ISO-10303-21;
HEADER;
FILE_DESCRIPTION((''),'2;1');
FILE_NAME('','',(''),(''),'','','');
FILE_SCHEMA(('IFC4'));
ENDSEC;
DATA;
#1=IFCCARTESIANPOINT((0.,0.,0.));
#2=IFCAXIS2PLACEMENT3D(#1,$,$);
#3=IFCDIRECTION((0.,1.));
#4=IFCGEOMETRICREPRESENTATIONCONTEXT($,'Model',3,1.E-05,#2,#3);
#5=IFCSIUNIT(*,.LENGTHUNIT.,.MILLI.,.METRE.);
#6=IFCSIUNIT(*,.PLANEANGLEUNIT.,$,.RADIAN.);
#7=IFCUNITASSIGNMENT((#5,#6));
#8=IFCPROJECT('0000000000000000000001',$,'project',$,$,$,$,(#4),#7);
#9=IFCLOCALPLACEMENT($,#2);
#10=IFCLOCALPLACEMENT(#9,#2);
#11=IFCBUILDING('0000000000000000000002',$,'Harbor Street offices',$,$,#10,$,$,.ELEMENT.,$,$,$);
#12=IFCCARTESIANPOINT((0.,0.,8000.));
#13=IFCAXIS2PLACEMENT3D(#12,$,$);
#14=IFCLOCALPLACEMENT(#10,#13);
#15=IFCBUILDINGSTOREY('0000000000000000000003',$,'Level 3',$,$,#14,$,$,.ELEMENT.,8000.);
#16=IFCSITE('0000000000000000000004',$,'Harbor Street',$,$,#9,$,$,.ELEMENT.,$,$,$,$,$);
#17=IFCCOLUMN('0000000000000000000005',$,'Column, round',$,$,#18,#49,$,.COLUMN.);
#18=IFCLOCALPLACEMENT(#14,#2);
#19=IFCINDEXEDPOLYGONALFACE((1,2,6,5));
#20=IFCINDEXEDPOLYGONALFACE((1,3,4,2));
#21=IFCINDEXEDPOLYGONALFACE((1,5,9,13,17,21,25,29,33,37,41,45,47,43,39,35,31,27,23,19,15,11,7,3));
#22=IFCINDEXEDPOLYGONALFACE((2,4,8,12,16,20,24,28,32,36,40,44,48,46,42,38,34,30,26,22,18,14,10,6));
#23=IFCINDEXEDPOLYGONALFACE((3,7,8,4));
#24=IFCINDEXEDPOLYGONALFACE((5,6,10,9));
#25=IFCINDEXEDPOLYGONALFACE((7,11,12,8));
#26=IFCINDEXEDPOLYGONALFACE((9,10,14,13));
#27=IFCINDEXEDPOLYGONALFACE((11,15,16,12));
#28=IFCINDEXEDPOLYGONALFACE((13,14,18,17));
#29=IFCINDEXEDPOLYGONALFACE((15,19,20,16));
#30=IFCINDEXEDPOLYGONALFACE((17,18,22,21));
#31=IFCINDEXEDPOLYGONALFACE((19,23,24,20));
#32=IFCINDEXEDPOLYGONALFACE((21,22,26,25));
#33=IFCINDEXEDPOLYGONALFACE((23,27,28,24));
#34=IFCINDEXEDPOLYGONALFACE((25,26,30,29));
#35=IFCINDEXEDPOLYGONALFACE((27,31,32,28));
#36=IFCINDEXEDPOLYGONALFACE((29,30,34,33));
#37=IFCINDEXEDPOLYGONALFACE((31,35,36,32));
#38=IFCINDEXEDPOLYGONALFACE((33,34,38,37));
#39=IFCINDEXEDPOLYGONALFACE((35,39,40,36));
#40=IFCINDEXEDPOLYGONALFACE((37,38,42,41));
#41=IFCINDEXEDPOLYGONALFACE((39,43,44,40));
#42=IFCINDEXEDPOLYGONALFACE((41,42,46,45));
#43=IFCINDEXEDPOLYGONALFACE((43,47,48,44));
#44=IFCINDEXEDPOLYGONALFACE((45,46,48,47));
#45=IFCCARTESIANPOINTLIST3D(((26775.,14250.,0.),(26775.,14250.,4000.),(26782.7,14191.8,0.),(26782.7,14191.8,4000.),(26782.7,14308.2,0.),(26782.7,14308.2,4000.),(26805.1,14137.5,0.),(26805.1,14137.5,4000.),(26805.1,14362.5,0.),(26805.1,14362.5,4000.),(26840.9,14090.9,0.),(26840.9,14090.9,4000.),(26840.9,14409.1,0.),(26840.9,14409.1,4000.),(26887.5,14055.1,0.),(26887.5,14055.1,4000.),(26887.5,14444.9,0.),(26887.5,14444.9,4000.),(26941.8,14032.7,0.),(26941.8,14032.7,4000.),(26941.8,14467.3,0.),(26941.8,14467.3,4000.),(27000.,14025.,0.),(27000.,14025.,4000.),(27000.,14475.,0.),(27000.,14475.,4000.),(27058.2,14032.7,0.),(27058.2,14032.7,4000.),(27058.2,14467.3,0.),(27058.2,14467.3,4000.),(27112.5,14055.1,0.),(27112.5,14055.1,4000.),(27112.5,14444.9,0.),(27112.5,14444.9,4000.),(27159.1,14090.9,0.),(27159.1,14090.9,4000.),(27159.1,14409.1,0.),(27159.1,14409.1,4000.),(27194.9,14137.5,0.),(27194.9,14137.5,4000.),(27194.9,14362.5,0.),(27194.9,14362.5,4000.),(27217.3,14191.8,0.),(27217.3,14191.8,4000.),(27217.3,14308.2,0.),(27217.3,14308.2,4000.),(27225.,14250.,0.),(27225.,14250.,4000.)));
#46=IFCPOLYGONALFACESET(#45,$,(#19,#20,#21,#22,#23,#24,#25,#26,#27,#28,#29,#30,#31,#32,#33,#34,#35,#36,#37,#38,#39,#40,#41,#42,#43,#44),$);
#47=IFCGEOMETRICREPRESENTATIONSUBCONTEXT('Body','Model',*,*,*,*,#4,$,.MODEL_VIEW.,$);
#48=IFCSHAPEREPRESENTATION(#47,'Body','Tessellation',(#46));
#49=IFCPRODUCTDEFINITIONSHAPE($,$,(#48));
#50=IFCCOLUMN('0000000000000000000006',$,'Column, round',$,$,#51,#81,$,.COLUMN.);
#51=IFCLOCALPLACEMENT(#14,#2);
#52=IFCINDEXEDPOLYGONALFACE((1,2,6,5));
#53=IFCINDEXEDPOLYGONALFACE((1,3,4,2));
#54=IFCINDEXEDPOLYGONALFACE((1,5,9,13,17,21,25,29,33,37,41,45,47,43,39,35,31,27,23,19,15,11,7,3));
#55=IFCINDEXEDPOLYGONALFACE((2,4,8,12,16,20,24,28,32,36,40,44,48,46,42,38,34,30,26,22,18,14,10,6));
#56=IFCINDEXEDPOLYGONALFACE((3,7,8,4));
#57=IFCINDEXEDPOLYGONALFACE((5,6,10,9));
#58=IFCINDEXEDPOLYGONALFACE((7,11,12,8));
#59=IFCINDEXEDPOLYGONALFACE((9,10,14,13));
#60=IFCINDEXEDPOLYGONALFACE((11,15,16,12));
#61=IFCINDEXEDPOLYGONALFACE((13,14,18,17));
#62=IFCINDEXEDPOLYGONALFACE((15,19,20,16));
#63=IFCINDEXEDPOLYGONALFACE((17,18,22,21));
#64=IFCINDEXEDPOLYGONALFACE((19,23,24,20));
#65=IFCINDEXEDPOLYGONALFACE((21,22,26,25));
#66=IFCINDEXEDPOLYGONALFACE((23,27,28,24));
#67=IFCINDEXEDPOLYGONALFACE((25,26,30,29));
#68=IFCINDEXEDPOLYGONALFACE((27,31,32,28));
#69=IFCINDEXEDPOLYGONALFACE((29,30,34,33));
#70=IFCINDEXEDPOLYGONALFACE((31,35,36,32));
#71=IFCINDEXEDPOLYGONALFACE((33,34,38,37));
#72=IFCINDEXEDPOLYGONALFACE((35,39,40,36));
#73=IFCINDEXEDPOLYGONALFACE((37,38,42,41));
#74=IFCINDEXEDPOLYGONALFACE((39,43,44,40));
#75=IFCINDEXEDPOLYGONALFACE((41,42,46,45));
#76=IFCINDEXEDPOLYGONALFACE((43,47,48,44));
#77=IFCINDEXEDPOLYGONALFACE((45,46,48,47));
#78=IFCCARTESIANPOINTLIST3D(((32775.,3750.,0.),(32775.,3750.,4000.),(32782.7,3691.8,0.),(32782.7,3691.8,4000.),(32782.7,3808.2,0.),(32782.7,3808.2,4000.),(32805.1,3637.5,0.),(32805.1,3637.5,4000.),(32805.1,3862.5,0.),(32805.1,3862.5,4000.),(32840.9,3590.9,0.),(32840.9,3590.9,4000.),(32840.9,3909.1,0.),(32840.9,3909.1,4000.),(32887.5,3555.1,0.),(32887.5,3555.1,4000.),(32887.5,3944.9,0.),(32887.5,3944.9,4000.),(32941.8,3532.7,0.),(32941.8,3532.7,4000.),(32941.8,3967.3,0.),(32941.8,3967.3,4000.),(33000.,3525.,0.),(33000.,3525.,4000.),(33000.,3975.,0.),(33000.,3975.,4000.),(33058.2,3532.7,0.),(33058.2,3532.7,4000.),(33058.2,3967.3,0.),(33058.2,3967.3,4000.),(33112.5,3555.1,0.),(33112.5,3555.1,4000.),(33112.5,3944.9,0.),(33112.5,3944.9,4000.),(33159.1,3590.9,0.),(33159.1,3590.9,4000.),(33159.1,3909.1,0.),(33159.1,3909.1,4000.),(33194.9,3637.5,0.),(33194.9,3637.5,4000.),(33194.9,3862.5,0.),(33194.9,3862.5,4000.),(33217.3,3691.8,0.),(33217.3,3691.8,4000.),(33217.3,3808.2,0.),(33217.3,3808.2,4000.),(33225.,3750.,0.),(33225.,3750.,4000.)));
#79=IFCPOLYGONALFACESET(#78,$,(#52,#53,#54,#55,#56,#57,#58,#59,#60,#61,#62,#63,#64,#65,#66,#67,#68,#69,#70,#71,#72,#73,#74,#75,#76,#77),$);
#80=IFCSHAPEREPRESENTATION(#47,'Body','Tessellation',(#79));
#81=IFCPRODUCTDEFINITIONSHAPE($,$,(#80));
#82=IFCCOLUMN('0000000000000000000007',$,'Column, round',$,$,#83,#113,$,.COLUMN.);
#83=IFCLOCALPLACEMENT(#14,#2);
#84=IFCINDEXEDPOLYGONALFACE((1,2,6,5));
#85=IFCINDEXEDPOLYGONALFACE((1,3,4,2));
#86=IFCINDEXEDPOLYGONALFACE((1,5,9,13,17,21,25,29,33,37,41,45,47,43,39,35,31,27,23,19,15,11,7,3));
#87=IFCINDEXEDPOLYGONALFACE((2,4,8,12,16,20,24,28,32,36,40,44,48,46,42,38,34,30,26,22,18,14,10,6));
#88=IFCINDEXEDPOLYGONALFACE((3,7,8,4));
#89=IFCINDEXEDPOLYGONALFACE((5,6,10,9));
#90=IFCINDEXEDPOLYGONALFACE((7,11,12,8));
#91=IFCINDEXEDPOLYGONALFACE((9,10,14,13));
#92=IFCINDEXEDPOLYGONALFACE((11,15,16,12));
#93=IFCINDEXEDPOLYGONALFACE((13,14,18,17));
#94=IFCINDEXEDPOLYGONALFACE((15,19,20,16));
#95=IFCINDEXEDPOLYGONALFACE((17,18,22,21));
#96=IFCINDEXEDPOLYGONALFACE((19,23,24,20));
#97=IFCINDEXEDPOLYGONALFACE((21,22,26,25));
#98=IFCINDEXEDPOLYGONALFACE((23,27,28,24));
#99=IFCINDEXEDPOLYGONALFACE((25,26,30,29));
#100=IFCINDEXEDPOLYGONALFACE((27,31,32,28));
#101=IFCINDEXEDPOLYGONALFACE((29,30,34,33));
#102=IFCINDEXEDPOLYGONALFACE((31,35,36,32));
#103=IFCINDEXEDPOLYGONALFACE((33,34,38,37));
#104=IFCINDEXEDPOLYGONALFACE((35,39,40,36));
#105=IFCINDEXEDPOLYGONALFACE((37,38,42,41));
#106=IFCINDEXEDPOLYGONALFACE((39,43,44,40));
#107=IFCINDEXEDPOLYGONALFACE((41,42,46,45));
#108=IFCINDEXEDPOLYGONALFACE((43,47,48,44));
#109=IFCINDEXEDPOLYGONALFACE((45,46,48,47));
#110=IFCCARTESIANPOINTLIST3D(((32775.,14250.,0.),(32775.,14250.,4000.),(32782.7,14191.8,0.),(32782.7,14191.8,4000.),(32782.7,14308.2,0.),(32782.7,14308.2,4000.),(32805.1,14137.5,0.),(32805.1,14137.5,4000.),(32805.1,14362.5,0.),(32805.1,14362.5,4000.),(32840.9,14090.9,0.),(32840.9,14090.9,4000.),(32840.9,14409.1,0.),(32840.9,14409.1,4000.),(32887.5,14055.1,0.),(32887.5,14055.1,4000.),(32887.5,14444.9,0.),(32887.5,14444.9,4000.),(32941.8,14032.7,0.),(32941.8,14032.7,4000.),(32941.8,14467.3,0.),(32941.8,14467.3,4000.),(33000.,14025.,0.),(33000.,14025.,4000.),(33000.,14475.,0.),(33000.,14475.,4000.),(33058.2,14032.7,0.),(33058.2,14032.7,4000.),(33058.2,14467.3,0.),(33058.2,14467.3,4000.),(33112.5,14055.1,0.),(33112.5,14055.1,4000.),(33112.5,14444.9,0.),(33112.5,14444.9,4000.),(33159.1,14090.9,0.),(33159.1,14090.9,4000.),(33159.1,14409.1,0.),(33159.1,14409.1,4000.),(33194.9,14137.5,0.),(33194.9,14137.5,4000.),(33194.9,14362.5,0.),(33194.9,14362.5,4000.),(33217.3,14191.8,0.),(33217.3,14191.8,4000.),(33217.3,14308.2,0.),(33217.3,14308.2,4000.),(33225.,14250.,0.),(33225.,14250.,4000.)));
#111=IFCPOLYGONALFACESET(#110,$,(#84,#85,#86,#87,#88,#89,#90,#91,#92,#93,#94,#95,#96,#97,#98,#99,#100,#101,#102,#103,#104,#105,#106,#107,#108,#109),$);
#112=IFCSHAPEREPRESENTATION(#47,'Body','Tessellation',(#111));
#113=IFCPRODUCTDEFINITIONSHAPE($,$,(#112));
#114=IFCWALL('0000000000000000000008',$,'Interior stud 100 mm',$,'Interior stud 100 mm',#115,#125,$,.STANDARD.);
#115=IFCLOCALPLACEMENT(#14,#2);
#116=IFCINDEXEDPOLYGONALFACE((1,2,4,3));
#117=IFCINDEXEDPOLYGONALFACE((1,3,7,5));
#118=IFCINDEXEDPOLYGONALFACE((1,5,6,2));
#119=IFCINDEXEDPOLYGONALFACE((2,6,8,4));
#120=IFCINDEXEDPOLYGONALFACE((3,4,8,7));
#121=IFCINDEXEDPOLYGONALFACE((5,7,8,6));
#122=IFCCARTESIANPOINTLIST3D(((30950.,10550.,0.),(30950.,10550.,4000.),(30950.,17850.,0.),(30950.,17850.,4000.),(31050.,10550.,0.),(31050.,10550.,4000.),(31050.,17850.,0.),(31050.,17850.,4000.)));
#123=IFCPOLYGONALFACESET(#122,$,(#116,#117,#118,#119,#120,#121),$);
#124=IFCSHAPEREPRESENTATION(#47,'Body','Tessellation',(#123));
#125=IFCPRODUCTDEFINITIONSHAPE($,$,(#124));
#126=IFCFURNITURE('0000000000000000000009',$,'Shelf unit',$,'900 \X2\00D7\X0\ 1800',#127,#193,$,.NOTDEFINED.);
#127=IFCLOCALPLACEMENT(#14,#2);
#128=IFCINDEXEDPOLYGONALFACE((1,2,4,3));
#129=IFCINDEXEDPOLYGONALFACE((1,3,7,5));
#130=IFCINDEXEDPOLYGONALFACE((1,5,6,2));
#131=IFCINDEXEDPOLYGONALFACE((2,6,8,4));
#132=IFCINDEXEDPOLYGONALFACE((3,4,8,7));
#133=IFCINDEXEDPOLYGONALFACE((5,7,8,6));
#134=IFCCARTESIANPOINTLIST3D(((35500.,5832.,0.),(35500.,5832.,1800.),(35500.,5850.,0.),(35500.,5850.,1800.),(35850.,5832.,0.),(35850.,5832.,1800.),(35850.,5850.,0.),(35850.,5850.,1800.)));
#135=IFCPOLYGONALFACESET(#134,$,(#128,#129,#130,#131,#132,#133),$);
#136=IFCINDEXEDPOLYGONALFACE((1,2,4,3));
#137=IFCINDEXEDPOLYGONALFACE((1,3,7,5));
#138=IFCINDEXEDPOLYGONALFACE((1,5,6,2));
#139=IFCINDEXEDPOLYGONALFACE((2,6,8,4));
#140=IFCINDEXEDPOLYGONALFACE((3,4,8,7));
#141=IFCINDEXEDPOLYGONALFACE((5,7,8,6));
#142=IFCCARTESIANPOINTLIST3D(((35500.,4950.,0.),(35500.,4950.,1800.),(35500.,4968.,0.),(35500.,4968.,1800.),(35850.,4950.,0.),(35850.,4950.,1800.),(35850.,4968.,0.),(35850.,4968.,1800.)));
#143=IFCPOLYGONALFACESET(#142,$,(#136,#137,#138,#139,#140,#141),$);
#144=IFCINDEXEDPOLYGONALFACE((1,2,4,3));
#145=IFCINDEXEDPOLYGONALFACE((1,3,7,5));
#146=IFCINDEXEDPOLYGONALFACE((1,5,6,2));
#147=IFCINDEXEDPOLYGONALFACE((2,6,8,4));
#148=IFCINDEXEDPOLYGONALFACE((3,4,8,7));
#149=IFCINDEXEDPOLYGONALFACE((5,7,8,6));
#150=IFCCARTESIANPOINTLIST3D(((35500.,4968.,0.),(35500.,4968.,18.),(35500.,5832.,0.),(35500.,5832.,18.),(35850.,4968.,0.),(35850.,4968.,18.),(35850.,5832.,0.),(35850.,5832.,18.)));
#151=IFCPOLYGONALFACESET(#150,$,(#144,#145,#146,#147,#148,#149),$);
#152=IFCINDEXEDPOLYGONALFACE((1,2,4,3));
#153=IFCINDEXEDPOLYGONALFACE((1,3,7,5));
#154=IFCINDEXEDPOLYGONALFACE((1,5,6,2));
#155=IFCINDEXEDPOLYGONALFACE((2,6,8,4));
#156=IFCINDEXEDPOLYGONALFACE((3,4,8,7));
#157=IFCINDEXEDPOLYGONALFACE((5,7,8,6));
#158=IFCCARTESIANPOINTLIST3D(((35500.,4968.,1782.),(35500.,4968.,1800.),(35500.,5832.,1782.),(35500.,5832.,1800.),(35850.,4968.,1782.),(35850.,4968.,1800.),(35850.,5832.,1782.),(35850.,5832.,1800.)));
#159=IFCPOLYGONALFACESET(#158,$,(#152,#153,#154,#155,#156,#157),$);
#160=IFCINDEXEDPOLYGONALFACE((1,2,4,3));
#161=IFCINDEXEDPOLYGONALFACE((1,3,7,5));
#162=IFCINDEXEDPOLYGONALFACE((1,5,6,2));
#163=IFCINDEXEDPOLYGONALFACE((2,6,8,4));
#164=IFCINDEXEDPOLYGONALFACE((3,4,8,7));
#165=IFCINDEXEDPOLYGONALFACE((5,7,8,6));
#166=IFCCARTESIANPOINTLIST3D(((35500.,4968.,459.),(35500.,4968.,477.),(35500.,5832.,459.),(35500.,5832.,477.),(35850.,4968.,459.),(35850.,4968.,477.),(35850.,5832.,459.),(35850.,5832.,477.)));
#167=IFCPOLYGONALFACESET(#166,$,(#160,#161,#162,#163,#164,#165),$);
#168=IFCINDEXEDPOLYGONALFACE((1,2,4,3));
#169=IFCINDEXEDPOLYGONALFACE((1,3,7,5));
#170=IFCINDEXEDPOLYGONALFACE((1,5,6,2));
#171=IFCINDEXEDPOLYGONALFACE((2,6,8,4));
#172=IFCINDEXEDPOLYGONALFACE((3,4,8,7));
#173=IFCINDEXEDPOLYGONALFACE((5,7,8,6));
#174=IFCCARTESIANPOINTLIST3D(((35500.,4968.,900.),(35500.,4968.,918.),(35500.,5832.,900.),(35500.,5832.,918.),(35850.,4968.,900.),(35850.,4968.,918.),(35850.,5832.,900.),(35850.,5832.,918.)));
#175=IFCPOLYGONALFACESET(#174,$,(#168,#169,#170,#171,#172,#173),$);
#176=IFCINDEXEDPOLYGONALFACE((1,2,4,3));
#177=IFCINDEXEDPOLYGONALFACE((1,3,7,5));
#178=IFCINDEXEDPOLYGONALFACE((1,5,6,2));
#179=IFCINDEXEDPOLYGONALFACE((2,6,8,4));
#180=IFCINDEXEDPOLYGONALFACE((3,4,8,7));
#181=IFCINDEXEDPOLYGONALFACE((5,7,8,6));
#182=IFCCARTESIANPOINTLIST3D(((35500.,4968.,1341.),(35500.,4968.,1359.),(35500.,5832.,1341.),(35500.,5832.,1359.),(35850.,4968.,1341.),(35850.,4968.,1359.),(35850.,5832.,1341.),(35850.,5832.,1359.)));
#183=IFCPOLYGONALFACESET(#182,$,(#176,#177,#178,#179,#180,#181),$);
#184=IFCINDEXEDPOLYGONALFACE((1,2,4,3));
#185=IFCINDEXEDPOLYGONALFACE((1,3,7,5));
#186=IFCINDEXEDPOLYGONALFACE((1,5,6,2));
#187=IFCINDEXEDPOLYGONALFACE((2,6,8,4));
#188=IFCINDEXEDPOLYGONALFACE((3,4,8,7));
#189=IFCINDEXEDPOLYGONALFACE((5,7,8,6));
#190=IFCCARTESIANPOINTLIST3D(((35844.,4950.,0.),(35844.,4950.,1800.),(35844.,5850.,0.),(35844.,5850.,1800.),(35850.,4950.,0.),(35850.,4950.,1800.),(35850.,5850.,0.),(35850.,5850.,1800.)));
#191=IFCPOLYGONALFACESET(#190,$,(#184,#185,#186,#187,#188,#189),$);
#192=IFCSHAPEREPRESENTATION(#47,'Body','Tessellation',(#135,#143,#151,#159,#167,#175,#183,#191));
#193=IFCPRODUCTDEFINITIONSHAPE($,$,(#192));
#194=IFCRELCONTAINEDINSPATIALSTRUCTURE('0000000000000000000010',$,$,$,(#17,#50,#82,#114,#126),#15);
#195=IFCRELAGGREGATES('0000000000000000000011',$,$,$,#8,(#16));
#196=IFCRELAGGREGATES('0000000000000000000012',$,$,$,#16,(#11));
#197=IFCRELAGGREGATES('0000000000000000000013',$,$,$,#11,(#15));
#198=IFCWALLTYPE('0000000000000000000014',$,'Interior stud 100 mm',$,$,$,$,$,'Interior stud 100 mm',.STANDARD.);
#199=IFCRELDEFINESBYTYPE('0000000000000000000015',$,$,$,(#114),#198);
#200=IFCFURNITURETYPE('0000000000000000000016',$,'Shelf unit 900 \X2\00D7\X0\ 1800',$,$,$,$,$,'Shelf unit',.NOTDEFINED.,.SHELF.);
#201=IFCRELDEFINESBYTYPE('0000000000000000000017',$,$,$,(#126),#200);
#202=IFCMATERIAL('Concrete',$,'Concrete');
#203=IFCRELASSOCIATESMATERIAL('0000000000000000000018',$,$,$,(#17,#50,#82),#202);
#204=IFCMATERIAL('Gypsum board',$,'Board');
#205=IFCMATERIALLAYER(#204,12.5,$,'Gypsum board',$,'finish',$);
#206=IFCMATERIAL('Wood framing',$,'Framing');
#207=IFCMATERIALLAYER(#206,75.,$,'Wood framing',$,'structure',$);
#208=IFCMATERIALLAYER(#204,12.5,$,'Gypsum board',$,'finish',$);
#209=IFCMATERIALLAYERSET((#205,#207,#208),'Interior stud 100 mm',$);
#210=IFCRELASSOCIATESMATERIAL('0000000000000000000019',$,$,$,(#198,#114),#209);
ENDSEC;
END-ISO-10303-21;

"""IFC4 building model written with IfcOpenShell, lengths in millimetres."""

from ifc_helpers import new_model, si_unit, direction, frame, origin, origin_2d, place, context, subcontext, project, spatial, polyline, circle, outline, extrude, source, transform, mapped, material, layer, layer_set, layer_usage, type_object, type_shapes, element, save


model = new_model("IFC4")

# Units and contexts
model_context = context("Model", 3, precision=1e-05, world=origin(), true_north=direction((0.0, 1.0)))
body_context = subcontext(model_context, "Body", "Model", "MODEL_VIEW")
ifc_project = project(units=[si_unit("LENGTHUNIT", "METRE", prefix="MILLI"), si_unit("PLANEANGLEUNIT", "RADIAN")], contexts=[model_context])

# Site, building, storey
site_placement = place(None, origin())
site = spatial("IfcSite", under=ifc_project, at=site_placement, Name="Harbor Street", CompositionType="ELEMENT")
building_placement = place(site_placement, origin())
building = spatial("IfcBuilding", under=site, at=building_placement, Name="Harbor Street offices", CompositionType="ELEMENT")
storey_placement = place(building_placement, frame((0.0, 0.0, 8000.0)))
storey = spatial("IfcBuildingStorey", under=building, at=storey_placement, Name="Level 3", CompositionType="ELEMENT", Elevation=8000.0)

# Columns
ifc_material_1 = material(Name="Concrete", Category="Concrete")
for number, where, z_axis, x_axis, name in (
    (1, (27000.0, 14250.0, 0.0), (0.0, 0.0, 1.0), (1.0, 0.0, 0.0), "Column, round"),
    (2, (33000.0, 3750.0, 0.0), (0.0, 0.0, 1.0), (1.0, 0.0, 0.0), "Column, round"),
    (3, (33000.0, 14250.0, 0.0), (0.0, 0.0, 1.0), (1.0, 0.0, 0.0), "Column, round"),
):
    element("IfcColumn", number, at=place(storey_placement, frame(where, z_axis=z_axis, x_axis=x_axis)), inside=storey, material=ifc_material_1, Name=name, PredefinedType="COLUMN", context=body_context, shape_type="SweptSolid", body=[
        extrude(circle(Radius=225.0, at=origin_2d()), origin(), (0.0, 0.0, 1.0), 4000.0),
    ])

# Wall
ifc_material_2 = material(Name="Gypsum board", Category="Board")
ifc_layer_1 = layer(ifc_material_2, 12.5, Name="Gypsum board", Category="finish")
ifc_material_3 = material(Name="Wood framing", Category="Framing")
ifc_layer_2 = layer(ifc_material_3, 75.0, Name="Wood framing", Category="structure")
ifc_layer_3 = layer(ifc_material_2, 12.5, Name="Gypsum board", Category="finish")
ifc_layer_set_1 = layer_set([ifc_layer_1, ifc_layer_2, ifc_layer_3], Name="Interior stud 100 mm")
ifc_layer_usage_1 = layer_usage(ifc_layer_set_1, "AXIS2", "NEGATIVE", 50.0)
wall_type_1 = type_object("IfcWallType", Name="Interior stud 100 mm", ElementType="Interior stud 100 mm", PredefinedType="STANDARD", material=ifc_layer_set_1)
wall_1_placement = place(storey_placement, frame((31000.0, 10500.0, 0.0), z_axis=(0.0, 0.0, 1.0), x_axis=(0.0, 1.0, 0.0)))
element("IfcWall", 4, at=wall_1_placement, inside=storey, type_object=wall_type_1, material=ifc_layer_usage_1, Name="Interior stud 100 mm", ObjectType="Interior stud 100 mm", PredefinedType="STANDARD", context=body_context, shape_type="SweptSolid", body=[
    extrude(outline(polyline([(50.0, -50.0), (7350.0, -50.0), (7350.0, 50.0), (50.0, 50.0), (50.0, -50.0)])), origin(), (0.0, 0.0, 1.0), 4000.0),
])

# Furniture
furniture_type_1 = type_object("IfcFurnitureType", Name="Shelf unit 900 × 1800", ElementType="Shelf unit", AssemblyPlace="NOTDEFINED", PredefinedType="SHELF")
shared_shape_1 = source(origin(), body_context, "Body", "SweptSolid", [
    extrude(outline(polyline([(-450.0, 0.0), (-432.0, 0.0), (-432.0, 350.0), (-450.0, 350.0), (-450.0, 0.0)])), origin(), (0.0, 0.0, 1.0), 1800.0),
    extrude(outline(polyline([(432.0, 0.0), (450.0, 0.0), (450.0, 350.0), (432.0, 350.0), (432.0, 0.0)])), origin(), (0.0, 0.0, 1.0), 1800.0),
    extrude(outline(polyline([(-432.0, 0.0), (432.0, 0.0), (432.0, 350.0), (-432.0, 350.0), (-432.0, 0.0)])), origin(), (0.0, 0.0, 1.0), 18.0),
    extrude(outline(polyline([(-432.0, 0.0), (432.0, 0.0), (432.0, 350.0), (-432.0, 350.0), (-432.0, 0.0)])), frame((0.0, 0.0, 1782.0)), (0.0, 0.0, 1.0), 18.0),
    extrude(outline(polyline([(-432.0, 0.0), (432.0, 0.0), (432.0, 350.0), (-432.0, 350.0), (-432.0, 0.0)])), frame((0.0, 0.0, 459.0)), (0.0, 0.0, 1.0), 18.0),
    extrude(outline(polyline([(-432.0, 0.0), (432.0, 0.0), (432.0, 350.0), (-432.0, 350.0), (-432.0, 0.0)])), frame((0.0, 0.0, 900.0)), (0.0, 0.0, 1.0), 18.0),
    extrude(outline(polyline([(-432.0, 0.0), (432.0, 0.0), (432.0, 350.0), (-432.0, 350.0), (-432.0, 0.0)])), frame((0.0, 0.0, 1341.0)), (0.0, 0.0, 1.0), 18.0),
    extrude(outline(polyline([(-450.0, 344.0), (450.0, 344.0), (450.0, 350.0), (-450.0, 350.0), (-450.0, 344.0)])), origin(), (0.0, 0.0, 1.0), 1800.0),
])
type_shapes(furniture_type_1, [shared_shape_1])
furniture_placement = place(storey_placement, frame((35500.0, 5400.0, 0.0), z_axis=(0.0, 0.0, 1.0), x_axis=(0.0, -1.0, 0.0)))
element("IfcFurniture", 5, at=furniture_placement, inside=storey, type_object=furniture_type_1, Name="Shelf unit", ObjectType="900 × 1800", PredefinedType="NOTDEFINED", context=body_context, shape_type="MappedRepresentation", body=[
    mapped(shared_shape_1, transform((0.0, 0.0, 0.0))),
])

save(model, "model.ifc")
